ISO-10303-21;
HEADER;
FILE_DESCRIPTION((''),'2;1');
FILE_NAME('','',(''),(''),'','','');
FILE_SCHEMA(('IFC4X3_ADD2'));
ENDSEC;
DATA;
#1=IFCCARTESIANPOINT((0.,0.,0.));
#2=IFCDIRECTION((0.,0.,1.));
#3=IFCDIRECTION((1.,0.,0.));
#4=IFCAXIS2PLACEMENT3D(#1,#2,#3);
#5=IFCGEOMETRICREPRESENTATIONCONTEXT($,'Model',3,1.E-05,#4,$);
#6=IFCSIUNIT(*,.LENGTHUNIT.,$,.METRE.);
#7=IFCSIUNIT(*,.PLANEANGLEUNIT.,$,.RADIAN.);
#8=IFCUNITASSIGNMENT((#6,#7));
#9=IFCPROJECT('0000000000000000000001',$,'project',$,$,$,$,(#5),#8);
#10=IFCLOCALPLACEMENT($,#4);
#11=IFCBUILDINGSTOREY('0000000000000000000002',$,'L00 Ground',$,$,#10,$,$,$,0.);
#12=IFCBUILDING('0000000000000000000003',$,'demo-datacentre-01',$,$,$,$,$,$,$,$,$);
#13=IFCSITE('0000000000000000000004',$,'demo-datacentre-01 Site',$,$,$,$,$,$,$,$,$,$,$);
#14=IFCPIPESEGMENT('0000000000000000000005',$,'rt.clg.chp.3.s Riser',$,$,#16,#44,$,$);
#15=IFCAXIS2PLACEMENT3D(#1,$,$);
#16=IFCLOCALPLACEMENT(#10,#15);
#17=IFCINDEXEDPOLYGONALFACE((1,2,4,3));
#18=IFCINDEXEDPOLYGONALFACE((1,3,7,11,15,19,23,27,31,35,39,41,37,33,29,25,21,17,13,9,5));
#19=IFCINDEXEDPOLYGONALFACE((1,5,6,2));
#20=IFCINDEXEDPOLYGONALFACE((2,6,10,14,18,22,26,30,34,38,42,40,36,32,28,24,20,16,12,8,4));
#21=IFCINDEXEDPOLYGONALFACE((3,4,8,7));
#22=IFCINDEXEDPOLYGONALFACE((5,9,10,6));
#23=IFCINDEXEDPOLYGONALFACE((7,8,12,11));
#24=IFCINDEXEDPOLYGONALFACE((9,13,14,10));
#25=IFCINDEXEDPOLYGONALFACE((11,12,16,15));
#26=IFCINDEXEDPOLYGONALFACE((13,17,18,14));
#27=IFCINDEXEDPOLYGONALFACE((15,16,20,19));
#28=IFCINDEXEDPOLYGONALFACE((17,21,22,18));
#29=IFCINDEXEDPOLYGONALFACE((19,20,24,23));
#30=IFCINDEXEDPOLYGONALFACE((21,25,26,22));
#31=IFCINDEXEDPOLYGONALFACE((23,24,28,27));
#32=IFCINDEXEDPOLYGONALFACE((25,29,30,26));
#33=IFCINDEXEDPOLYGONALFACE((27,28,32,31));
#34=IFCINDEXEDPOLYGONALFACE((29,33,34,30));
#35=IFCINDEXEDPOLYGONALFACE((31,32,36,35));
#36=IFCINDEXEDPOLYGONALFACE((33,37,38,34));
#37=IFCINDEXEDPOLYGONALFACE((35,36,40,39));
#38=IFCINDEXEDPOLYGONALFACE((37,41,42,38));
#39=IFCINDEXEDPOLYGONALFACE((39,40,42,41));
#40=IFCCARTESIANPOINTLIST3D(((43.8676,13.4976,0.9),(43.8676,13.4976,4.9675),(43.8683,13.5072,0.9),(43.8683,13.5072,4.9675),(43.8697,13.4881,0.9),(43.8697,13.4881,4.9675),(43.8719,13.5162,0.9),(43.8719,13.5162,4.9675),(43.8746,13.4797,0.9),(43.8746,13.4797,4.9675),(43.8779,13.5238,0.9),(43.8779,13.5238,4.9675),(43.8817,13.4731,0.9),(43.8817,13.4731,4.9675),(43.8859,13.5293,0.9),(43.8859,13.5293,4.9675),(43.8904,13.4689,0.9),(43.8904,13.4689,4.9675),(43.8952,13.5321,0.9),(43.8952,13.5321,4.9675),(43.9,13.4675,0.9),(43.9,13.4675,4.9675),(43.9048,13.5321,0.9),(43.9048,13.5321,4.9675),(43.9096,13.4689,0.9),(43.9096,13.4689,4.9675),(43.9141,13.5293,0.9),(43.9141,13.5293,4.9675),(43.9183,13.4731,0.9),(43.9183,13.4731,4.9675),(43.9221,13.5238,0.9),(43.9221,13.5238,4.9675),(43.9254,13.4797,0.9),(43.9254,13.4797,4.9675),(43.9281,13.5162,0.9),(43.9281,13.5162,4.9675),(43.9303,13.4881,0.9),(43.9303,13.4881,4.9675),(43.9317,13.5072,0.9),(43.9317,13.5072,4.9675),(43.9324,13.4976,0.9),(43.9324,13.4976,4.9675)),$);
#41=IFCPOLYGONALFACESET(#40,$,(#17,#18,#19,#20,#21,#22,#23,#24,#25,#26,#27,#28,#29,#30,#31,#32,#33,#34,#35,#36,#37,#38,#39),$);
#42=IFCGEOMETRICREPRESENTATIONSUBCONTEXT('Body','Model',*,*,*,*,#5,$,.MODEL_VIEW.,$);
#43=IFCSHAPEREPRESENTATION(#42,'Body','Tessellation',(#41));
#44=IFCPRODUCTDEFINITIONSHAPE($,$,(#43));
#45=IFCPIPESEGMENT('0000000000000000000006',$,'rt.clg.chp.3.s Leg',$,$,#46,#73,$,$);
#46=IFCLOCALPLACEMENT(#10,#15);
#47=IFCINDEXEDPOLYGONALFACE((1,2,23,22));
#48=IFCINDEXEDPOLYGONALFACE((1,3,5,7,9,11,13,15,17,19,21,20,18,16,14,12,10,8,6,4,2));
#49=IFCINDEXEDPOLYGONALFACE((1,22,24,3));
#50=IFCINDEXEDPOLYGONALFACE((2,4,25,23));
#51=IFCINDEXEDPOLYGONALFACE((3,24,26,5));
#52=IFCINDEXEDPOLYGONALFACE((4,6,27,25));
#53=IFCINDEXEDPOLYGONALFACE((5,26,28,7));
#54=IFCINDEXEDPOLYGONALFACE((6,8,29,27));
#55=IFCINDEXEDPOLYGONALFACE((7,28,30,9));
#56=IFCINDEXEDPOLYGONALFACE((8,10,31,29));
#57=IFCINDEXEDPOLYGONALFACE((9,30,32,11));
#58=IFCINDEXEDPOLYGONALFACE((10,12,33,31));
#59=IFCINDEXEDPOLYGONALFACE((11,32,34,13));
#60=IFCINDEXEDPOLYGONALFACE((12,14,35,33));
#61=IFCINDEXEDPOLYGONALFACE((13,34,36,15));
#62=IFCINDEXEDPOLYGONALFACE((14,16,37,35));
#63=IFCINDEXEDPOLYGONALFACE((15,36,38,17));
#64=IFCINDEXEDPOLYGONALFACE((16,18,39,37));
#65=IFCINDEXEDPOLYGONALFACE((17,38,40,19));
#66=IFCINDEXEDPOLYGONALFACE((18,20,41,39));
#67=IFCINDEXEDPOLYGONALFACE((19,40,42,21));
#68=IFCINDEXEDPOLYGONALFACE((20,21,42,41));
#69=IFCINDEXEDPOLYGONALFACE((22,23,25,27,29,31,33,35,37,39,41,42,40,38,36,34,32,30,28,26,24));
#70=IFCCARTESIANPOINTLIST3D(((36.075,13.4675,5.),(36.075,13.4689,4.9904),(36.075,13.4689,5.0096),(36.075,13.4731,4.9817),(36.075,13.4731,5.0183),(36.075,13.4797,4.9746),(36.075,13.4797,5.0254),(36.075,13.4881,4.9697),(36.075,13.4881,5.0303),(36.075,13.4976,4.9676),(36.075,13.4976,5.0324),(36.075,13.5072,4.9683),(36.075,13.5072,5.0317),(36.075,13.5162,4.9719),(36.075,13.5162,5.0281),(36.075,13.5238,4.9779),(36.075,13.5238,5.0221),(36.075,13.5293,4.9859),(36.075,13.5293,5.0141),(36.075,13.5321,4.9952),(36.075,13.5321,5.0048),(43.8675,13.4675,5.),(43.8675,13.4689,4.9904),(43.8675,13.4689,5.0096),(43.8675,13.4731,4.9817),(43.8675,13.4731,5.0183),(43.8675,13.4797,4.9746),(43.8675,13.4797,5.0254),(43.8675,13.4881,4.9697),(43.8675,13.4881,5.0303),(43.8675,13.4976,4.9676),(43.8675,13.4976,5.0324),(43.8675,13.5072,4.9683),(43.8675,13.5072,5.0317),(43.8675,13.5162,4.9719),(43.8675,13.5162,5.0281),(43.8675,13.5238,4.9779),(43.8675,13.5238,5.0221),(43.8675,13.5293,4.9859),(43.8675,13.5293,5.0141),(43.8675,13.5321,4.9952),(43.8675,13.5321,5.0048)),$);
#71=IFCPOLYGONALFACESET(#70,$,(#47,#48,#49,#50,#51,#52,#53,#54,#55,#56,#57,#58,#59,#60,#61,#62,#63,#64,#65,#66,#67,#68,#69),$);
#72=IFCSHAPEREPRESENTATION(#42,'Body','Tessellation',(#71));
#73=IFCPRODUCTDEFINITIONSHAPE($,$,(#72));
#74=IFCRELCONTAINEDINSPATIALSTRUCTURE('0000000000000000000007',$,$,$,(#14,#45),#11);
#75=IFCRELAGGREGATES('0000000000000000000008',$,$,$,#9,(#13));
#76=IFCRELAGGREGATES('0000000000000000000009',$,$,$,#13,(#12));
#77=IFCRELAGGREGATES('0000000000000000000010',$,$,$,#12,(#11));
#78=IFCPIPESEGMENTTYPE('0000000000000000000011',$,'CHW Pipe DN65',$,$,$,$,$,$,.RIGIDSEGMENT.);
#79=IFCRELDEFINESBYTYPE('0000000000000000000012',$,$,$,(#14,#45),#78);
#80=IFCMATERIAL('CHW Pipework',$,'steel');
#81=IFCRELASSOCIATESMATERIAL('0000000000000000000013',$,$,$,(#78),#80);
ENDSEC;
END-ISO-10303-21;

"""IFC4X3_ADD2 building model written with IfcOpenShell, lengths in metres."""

from ifc_helpers import new_model, si_unit, frame, origin_with_axes, place, context, subcontext, project, spatial, circle, extrude, material, type_object, element, save


model = new_model("IFC4X3_ADD2")

# Units and contexts
model_context = context("Model", 3, precision=1e-05, world=origin_with_axes())
body_context = subcontext(model_context, "Body", "Model", "MODEL_VIEW")
ifc_project = project(units=[si_unit("LENGTHUNIT", "METRE"), si_unit("PLANEANGLEUNIT", "RADIAN")], contexts=[model_context])

# Site, building, storey
site = spatial("IfcSite", under=ifc_project, Name="demo-datacentre-01 Site")
building = spatial("IfcBuilding", under=site, Name="demo-datacentre-01")
storey_placement = place(None, origin_with_axes())
storey = spatial("IfcBuildingStorey", under=building, at=storey_placement, Name="L00 Ground", Elevation=0.0)

# Shared definitions
ifc_material = material(Name="CHW Pipework", Category="steel")

# Pipe segments
pipe_segment_type_1 = type_object("IfcPipeSegmentType", Name="CHW Pipe DN65", PredefinedType="RIGIDSEGMENT", material=ifc_material)
pipe_segment_1_placement = place(storey_placement, frame((43.9, 13.5, 0.9), z_axis=(0.0, 0.0, 1.0), x_axis=(0.0, -1.0, 0.0)))
element("IfcPipeSegment", 1, at=pipe_segment_1_placement, inside=storey, type_object=pipe_segment_type_1, Name="rt.clg.chp.3.s Riser", context=body_context, shape_type="SweptSolid", body=[
    extrude(circle(Radius=0.0325), origin_with_axes(), (0.0, 0.0, 1.0), 4.0675),
])
pipe_segment_2_placement = place(storey_placement, frame((43.8675, 13.5, 5.0), z_axis=(-1.0, 0.0, 0.0), x_axis=(0.0, -1.0, 0.0)))
element("IfcPipeSegment", 2, at=pipe_segment_2_placement, inside=storey, type_object=pipe_segment_type_1, Name="rt.clg.chp.3.s Leg", context=body_context, shape_type="SweptSolid", body=[
    extrude(circle(Radius=0.0325), origin_with_axes(), (0.0, 0.0, 1.0), 7.7925),
])

save(model, "model.ifc")
